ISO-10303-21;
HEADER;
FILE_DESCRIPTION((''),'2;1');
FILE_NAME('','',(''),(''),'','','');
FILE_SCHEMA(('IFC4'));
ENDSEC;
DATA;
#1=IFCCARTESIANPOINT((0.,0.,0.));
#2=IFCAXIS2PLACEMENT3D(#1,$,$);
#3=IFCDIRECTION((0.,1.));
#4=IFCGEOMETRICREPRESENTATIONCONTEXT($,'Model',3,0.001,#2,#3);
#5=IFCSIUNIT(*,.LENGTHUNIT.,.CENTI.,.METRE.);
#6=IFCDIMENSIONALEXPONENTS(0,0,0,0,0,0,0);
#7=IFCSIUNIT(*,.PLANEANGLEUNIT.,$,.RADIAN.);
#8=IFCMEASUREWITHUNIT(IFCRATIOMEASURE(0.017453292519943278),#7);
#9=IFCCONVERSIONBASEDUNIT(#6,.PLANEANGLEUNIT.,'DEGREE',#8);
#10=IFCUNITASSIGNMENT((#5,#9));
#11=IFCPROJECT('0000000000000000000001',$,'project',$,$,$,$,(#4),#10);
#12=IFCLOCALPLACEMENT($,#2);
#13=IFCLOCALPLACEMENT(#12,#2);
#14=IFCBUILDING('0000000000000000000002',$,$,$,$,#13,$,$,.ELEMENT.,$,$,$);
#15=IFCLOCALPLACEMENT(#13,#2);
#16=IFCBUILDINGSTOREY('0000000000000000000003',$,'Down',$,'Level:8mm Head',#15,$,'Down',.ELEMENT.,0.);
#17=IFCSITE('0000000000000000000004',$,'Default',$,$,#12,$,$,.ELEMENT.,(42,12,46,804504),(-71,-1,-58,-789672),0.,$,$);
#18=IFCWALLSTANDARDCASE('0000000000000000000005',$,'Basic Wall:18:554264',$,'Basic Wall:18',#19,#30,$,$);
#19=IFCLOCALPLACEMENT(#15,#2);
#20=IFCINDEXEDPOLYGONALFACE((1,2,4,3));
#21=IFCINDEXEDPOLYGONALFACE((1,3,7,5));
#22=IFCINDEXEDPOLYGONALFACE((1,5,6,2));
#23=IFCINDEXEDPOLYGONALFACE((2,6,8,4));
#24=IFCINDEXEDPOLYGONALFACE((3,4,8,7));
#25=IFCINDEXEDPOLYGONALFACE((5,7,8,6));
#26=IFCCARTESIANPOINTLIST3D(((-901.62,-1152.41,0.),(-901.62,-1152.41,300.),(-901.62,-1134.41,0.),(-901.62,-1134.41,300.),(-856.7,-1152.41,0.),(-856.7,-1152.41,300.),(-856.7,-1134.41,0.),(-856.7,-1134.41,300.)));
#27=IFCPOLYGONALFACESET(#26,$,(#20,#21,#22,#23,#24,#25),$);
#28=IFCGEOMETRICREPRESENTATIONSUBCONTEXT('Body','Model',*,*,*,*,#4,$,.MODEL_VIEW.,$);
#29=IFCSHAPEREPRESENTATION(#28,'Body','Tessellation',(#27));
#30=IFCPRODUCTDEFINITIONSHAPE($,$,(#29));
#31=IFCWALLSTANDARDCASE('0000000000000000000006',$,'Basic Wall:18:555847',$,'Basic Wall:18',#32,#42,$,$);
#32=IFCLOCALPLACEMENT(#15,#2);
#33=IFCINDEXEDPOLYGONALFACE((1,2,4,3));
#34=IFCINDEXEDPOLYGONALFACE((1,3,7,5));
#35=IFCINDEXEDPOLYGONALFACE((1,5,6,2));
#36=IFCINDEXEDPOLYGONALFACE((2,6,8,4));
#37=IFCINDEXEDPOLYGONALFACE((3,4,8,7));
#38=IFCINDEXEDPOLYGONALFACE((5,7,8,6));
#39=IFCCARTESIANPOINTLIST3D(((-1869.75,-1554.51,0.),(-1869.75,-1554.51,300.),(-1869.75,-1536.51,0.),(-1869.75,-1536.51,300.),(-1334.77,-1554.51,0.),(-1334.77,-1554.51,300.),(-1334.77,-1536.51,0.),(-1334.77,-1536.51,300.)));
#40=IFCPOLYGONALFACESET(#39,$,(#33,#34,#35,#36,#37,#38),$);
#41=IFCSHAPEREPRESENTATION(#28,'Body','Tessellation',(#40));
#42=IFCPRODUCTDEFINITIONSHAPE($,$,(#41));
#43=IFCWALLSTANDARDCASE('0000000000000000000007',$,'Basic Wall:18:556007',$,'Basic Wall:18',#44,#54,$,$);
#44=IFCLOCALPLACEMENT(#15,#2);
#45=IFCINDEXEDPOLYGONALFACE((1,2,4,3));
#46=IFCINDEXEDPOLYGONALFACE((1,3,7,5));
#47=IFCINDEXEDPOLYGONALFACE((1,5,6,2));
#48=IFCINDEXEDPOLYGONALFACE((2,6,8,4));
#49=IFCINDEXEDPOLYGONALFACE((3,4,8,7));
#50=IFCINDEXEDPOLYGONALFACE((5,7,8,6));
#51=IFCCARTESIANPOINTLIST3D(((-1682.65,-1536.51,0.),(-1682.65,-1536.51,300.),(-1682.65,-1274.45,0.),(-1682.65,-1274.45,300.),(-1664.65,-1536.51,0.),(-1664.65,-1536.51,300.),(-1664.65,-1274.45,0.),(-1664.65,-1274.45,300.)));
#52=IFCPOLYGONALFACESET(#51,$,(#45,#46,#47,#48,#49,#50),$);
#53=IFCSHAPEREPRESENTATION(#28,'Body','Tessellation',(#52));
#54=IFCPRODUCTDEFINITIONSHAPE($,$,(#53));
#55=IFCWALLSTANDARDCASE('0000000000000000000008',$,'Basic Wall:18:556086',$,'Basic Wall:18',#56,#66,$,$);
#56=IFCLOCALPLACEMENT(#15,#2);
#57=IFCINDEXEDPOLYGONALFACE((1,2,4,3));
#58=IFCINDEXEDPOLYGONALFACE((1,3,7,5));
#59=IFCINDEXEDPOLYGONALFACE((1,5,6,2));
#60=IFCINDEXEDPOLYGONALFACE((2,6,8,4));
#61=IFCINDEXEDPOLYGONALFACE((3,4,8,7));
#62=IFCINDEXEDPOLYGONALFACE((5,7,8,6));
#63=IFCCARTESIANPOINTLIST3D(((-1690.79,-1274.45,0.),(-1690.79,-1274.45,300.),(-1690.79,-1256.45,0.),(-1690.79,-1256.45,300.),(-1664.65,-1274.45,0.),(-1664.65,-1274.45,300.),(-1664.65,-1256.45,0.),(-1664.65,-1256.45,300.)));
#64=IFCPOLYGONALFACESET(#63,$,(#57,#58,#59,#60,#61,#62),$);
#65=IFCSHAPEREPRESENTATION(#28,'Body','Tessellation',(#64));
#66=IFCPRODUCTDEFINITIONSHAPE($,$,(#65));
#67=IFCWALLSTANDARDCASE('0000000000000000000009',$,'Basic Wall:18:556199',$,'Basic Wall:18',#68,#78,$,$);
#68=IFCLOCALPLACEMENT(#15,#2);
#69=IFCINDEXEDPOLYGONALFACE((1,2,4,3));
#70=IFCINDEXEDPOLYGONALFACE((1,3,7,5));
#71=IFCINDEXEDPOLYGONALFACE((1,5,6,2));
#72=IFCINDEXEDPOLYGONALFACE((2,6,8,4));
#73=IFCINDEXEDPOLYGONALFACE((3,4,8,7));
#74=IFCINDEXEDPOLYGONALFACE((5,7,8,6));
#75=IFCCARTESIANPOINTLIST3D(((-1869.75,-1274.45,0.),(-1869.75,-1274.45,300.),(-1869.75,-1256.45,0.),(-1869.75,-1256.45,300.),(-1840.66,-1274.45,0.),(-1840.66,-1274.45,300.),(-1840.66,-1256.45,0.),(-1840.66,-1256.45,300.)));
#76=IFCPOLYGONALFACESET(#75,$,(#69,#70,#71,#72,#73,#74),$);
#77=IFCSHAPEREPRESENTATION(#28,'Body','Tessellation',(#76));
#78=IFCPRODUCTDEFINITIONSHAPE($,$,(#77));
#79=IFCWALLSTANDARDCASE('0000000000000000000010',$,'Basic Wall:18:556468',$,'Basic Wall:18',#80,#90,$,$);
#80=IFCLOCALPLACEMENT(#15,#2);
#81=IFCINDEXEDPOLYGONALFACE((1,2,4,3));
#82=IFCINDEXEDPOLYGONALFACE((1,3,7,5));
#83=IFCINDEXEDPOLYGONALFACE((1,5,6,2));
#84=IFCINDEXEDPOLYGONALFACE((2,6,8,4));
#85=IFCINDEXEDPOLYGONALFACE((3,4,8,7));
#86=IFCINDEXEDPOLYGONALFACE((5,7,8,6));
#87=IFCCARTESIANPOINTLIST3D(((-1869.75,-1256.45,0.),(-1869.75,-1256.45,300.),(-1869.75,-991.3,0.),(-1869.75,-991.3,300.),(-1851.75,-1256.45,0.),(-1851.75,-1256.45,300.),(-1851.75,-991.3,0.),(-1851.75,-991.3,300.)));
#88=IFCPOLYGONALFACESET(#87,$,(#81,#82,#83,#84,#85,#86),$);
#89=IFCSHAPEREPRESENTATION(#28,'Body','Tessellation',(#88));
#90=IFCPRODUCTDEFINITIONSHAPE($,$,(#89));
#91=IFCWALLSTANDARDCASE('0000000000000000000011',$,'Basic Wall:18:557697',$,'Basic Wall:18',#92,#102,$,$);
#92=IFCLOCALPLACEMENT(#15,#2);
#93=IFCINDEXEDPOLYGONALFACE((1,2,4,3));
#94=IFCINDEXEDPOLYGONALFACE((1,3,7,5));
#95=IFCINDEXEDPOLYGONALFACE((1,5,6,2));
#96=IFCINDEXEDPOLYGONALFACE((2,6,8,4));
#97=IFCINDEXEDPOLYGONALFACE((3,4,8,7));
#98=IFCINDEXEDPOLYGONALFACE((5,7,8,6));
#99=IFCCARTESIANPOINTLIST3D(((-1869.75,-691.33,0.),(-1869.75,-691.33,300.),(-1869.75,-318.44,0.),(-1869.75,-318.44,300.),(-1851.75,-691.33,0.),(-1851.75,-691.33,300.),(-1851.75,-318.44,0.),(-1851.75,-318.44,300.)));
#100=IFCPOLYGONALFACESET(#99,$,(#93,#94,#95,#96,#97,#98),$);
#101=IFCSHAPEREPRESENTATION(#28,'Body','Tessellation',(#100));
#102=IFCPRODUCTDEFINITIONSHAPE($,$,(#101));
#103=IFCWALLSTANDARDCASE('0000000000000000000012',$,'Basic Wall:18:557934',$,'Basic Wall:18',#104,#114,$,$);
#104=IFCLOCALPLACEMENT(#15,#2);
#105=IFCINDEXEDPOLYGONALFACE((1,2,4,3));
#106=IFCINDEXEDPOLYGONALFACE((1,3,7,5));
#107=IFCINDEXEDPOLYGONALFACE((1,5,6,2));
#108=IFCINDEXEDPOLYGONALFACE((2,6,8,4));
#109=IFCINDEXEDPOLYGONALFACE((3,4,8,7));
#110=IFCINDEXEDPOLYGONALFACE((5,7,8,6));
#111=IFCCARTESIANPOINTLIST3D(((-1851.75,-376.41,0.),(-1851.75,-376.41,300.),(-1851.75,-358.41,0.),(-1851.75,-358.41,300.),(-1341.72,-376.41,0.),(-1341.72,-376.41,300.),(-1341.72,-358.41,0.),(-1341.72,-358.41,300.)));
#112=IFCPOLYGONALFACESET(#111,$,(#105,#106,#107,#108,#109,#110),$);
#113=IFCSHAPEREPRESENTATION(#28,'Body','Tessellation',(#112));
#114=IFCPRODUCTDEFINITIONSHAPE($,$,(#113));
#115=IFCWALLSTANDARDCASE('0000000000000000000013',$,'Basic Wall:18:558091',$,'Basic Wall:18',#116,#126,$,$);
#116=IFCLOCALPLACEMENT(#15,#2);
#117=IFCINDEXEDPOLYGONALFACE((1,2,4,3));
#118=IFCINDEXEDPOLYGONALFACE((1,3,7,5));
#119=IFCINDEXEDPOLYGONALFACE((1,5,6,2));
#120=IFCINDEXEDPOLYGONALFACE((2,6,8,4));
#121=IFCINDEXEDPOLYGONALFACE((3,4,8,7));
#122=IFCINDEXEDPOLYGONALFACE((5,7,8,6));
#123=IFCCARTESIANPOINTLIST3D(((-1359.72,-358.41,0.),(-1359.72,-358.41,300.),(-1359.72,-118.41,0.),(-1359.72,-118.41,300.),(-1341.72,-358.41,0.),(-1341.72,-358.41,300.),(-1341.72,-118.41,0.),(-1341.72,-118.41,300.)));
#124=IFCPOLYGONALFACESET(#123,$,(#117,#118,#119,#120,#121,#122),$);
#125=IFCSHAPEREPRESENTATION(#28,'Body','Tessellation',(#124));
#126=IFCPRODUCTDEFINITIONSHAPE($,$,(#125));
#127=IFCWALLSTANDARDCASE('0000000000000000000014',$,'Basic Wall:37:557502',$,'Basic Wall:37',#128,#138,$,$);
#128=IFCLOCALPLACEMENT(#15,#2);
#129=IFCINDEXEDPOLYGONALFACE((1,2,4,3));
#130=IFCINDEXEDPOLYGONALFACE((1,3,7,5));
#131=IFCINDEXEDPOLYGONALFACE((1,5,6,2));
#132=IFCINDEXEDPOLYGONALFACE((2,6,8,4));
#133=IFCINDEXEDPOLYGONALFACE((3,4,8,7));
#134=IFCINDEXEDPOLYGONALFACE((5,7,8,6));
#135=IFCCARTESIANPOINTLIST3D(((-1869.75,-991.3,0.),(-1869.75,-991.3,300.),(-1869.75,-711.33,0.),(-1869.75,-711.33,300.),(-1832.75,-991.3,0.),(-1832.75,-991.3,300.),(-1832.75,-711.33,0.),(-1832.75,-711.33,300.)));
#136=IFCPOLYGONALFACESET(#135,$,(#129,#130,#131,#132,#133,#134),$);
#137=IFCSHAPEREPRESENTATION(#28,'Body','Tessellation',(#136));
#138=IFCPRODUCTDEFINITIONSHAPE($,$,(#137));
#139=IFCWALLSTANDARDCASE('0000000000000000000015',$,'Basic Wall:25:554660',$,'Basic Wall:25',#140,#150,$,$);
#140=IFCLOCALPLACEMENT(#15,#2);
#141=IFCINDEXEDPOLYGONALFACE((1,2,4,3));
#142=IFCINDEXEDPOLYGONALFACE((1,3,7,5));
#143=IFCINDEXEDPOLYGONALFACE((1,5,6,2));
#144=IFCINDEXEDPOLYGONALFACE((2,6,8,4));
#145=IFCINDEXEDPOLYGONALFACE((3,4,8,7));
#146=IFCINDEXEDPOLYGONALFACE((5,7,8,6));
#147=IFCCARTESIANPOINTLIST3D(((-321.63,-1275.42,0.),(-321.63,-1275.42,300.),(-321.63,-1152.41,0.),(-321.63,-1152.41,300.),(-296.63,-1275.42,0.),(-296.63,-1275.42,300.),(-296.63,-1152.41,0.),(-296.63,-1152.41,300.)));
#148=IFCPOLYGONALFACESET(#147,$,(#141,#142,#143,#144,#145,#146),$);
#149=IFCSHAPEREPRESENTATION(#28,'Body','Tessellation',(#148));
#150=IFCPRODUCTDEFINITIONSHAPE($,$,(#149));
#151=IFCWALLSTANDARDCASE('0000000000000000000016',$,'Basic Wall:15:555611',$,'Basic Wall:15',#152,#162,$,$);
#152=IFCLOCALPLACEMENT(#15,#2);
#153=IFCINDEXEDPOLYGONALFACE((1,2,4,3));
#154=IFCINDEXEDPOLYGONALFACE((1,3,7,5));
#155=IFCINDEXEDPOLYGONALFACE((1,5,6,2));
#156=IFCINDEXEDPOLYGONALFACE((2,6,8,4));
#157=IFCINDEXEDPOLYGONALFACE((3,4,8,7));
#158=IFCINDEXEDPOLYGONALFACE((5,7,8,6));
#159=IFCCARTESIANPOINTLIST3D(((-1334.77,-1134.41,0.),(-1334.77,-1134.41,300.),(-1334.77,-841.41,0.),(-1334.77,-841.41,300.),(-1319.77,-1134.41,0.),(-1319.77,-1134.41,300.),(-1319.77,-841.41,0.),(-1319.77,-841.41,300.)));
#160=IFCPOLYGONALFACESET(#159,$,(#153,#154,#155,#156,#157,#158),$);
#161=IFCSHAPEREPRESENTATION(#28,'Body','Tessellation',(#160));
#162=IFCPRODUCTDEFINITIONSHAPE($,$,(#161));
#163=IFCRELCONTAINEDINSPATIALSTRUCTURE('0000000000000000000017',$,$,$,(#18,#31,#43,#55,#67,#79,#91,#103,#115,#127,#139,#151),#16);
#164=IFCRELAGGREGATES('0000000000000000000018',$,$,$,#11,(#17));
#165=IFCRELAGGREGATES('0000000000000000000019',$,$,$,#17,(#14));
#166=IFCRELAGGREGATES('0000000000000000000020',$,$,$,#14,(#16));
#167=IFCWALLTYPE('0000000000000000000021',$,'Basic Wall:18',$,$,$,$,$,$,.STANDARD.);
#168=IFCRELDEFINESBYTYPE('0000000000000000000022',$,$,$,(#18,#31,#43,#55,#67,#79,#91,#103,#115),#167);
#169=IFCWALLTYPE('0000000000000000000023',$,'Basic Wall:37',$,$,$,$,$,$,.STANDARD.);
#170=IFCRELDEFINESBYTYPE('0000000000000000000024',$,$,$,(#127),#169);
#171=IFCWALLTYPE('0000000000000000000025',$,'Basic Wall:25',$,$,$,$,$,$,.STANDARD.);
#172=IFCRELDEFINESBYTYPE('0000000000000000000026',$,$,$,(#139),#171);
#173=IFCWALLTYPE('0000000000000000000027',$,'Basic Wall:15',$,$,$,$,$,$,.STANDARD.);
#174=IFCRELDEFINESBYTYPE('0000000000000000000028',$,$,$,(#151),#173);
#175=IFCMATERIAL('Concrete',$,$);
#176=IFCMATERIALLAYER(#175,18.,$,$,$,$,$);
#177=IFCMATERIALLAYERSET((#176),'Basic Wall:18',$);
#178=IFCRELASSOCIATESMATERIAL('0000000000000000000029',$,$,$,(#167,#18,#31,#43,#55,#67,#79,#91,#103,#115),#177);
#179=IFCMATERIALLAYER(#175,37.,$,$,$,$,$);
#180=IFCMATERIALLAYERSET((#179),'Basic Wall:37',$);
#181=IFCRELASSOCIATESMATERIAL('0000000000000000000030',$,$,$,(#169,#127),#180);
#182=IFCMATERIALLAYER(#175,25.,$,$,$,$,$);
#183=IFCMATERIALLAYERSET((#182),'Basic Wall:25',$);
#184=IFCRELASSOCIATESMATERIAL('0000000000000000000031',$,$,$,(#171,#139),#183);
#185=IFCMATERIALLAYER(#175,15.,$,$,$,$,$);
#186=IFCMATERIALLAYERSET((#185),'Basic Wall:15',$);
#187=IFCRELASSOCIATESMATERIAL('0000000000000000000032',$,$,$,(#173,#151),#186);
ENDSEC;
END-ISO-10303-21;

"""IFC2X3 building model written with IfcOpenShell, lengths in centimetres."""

from ifc_helpers import new_model, entity, si_unit, converted_unit, direction, frame, frame_2d, origin, place, context, subcontext, project, spatial, rectangle, extrude, material, layer, layer_set, layer_usage, type_object, element, save


model = new_model("IFC2X3")

# Units and contexts
model_context = context("Model", 3, precision=0.001, world=origin(), true_north=direction((0.0, 1.0)))
body_context = subcontext(model_context, "Body", "Model", "MODEL_VIEW")
ifc_project = project(units=[si_unit("LENGTHUNIT", "METRE", prefix="CENTI"), converted_unit("PLANEANGLEUNIT", "DEGREE", entity("IfcRatioMeasure", 0.017453292519943278), si_unit("PLANEANGLEUNIT", "RADIAN"), dimensions=[0, 0, 0, 0, 0, 0, 0])], contexts=[model_context])

# Site, building, storey
site_placement = place(None, origin())
site = spatial("IfcSite", under=ifc_project, at=site_placement, Name="Default", CompositionType="ELEMENT", RefLatitude=(42, 12, 46, 804504), RefLongitude=(-71, -1, -58, -789672), RefElevation=0.0)
building_placement = place(site_placement, origin())
building = spatial("IfcBuilding", under=site, at=building_placement, CompositionType="ELEMENT")
storey_placement = place(building_placement, origin())
storey = spatial("IfcBuildingStorey", under=building, at=storey_placement, Name="Down", ObjectType="Level:8mm Head", LongName="Down", CompositionType="ELEMENT", Elevation=0.0)

# Walls
ifc_material = material(Name="Concrete")
ifc_layer_1 = layer(ifc_material, 18.0)
ifc_layer_set_1 = layer_set([ifc_layer_1], Name="Basic Wall:18")
wall_type_1 = type_object("IfcWallType", Name="Basic Wall:18", PredefinedType="STANDARD", material=ifc_layer_set_1)
ifc_layer_usage_1 = layer_usage(ifc_layer_set_1, "AXIS2", "POSITIVE", -9.0)
wall_1_placement = place(storey_placement, frame((-856.7, -1143.41, 0.0), z_axis=(0.0, 0.0, 1.0), x_axis=(-1.0, 0.0, 0.0)))
element("IfcWallStandardCase", 1, at=wall_1_placement, inside=storey, type_object=wall_type_1, material=ifc_layer_usage_1, Name="Basic Wall:18:554264", ObjectType="Basic Wall:18", context=body_context, shape_type="SweptSolid", body=[
    extrude(rectangle(XDim=44.92, YDim=18.0, at=frame_2d((22.46, 0.0), x_axis=(-1.0, 0.0))), origin(), (0.0, 0.0, 1.0), 300.0),
])
ifc_layer_usage_2 = layer_usage(ifc_layer_set_1, "AXIS2", "NEGATIVE", 9.0)
wall_2_placement = place(storey_placement, frame((-1334.77, -1545.51, 0.0), z_axis=(0.0, 0.0, 1.0), x_axis=(-1.0, 0.0, 0.0)))
element("IfcWallStandardCase", 2, at=wall_2_placement, inside=storey, type_object=wall_type_1, material=ifc_layer_usage_2, Name="Basic Wall:18:555847", ObjectType="Basic Wall:18", context=body_context, shape_type="SweptSolid", body=[
    extrude(rectangle(XDim=534.98, YDim=18.0, at=frame_2d((267.49, 0.0), x_axis=(-1.0, 0.0))), origin(), (0.0, 0.0, 1.0), 300.0),
])
ifc_layer_usage_3 = layer_usage(ifc_layer_set_1, "AXIS2", "POSITIVE", -9.0)
wall_3_placement = place(storey_placement, frame((-1673.65, -1536.51, 0.0), z_axis=(0.0, 0.0, 1.0), x_axis=(0.0, 1.0, 0.0)))
element("IfcWallStandardCase", 3, at=wall_3_placement, inside=storey, type_object=wall_type_1, material=ifc_layer_usage_3, Name="Basic Wall:18:556007", ObjectType="Basic Wall:18", context=body_context, shape_type="SweptSolid", body=[
    extrude(rectangle(XDim=262.05, YDim=18.0, at=frame_2d((131.03, 0.0), x_axis=(-1.0, 0.0))), origin(), (0.0, 0.0, 1.0), 300.0),
])
ifc_layer_usage_4 = layer_usage(ifc_layer_set_1, "AXIS2", "POSITIVE", -9.0)
wall_4_placement = place(storey_placement, frame((-1664.65, -1265.45, 0.0), z_axis=(0.0, 0.0, 1.0), x_axis=(-1.0, 0.0, 0.0)))
element("IfcWallStandardCase", 4, at=wall_4_placement, inside=storey, type_object=wall_type_1, material=ifc_layer_usage_4, Name="Basic Wall:18:556086", ObjectType="Basic Wall:18", context=body_context, shape_type="SweptSolid", body=[
    extrude(rectangle(XDim=26.14, YDim=18.0, at=frame_2d((13.07, 0.0), x_axis=(-1.0, 0.0))), origin(), (0.0, 0.0, 1.0), 300.0),
])
ifc_layer_usage_5 = layer_usage(ifc_layer_set_1, "AXIS2", "POSITIVE", -9.0)
wall_5_placement = place(storey_placement, frame((-1840.66, -1265.45, 0.0), z_axis=(0.0, 0.0, 1.0), x_axis=(-1.0, 0.0, 0.0)))
element("IfcWallStandardCase", 5, at=wall_5_placement, inside=storey, type_object=wall_type_1, material=ifc_layer_usage_5, Name="Basic Wall:18:556199", ObjectType="Basic Wall:18", context=body_context, shape_type="SweptSolid", body=[
    extrude(rectangle(XDim=29.09, YDim=18.0, at=frame_2d((14.54, 0.0), x_axis=(-1.0, 0.0))), origin(), (0.0, 0.0, 1.0), 300.0),
])
ifc_layer_usage_6 = layer_usage(ifc_layer_set_1, "AXIS2", "NEGATIVE", 9.0)
wall_6_placement = place(storey_placement, frame((-1860.75, -1256.45, 0.0), z_axis=(0.0, 0.0, 1.0), x_axis=(0.0, 1.0, 0.0)))
element("IfcWallStandardCase", 6, at=wall_6_placement, inside=storey, type_object=wall_type_1, material=ifc_layer_usage_6, Name="Basic Wall:18:556468", ObjectType="Basic Wall:18", context=body_context, shape_type="SweptSolid", body=[
    extrude(rectangle(XDim=265.15, YDim=18.0, at=frame_2d((132.57, 0.0), x_axis=(-1.0, 0.0))), origin(), (0.0, 0.0, 1.0), 300.0),
])
ifc_layer_usage_7 = layer_usage(ifc_layer_set_1, "AXIS2", "NEGATIVE", 9.0)
wall_7_placement = place(storey_placement, frame((-1860.75, -691.33, 0.0), z_axis=(0.0, 0.0, 1.0), x_axis=(0.0, 1.0, 0.0)))
element("IfcWallStandardCase", 7, at=wall_7_placement, inside=storey, type_object=wall_type_1, material=ifc_layer_usage_7, Name="Basic Wall:18:557697", ObjectType="Basic Wall:18", context=body_context, shape_type="SweptSolid", body=[
    extrude(rectangle(XDim=372.88, YDim=18.0, at=frame_2d((186.44, 0.0), x_axis=(-1.0, 0.0))), origin(), (0.0, 0.0, 1.0), 300.0),
])
ifc_layer_usage_8 = layer_usage(ifc_layer_set_1, "AXIS2", "POSITIVE", -9.0)
wall_8_placement = place(storey_placement, frame((-1851.75, -367.41, 0.0)))
element("IfcWallStandardCase", 8, at=wall_8_placement, inside=storey, type_object=wall_type_1, material=ifc_layer_usage_8, Name="Basic Wall:18:557934", ObjectType="Basic Wall:18", context=body_context, shape_type="SweptSolid", body=[
    extrude(rectangle(XDim=510.02, YDim=18.0, at=frame_2d((255.01, 0.0), x_axis=(-1.0, 0.0))), origin(), (0.0, 0.0, 1.0), 300.0),
])
ifc_layer_usage_9 = layer_usage(ifc_layer_set_1, "AXIS2", "POSITIVE", -9.0)
wall_9_placement = place(storey_placement, frame((-1350.72, -358.41, 0.0), z_axis=(0.0, 0.0, 1.0), x_axis=(0.0, 1.0, 0.0)))
element("IfcWallStandardCase", 9, at=wall_9_placement, inside=storey, type_object=wall_type_1, material=ifc_layer_usage_9, Name="Basic Wall:18:558091", ObjectType="Basic Wall:18", context=body_context, shape_type="SweptSolid", body=[
    extrude(rectangle(XDim=240.0, YDim=18.0, at=frame_2d((120.0, 0.0), x_axis=(-1.0, 0.0))), origin(), (0.0, 0.0, 1.0), 300.0),
])
ifc_layer_2 = layer(ifc_material, 37.0)
ifc_layer_set_2 = layer_set([ifc_layer_2], Name="Basic Wall:37")
ifc_layer_usage_10 = layer_usage(ifc_layer_set_2, "AXIS2", "NEGATIVE", 18.5)
wall_type_2 = type_object("IfcWallType", Name="Basic Wall:37", PredefinedType="STANDARD", material=ifc_layer_set_2)
wall_10_placement = place(storey_placement, frame((-1851.25, -991.3, 0.0), z_axis=(0.0, 0.0, 1.0), x_axis=(0.0, 1.0, 0.0)))
element("IfcWallStandardCase", 10, at=wall_10_placement, inside=storey, type_object=wall_type_2, material=ifc_layer_usage_10, Name="Basic Wall:37:557502", ObjectType="Basic Wall:37", context=body_context, shape_type="SweptSolid", body=[
    extrude(rectangle(XDim=279.98, YDim=37.0, at=frame_2d((139.99, 0.0), x_axis=(-1.0, 0.0))), origin(), (0.0, 0.0, 1.0), 300.0),
])
ifc_layer_3 = layer(ifc_material, 25.0)
ifc_layer_set_3 = layer_set([ifc_layer_3], Name="Basic Wall:25")
ifc_layer_usage_11 = layer_usage(ifc_layer_set_3, "AXIS2", "NEGATIVE", 12.5)
wall_type_3 = type_object("IfcWallType", Name="Basic Wall:25", PredefinedType="STANDARD", material=ifc_layer_set_3)
wall_11_placement = place(storey_placement, frame((-309.13, -1152.41, 0.0), z_axis=(0.0, 0.0, 1.0), x_axis=(0.0, -1.0, 0.0)))
element("IfcWallStandardCase", 11, at=wall_11_placement, inside=storey, type_object=wall_type_3, material=ifc_layer_usage_11, Name="Basic Wall:25:554660", ObjectType="Basic Wall:25", context=body_context, shape_type="SweptSolid", body=[
    extrude(rectangle(XDim=123.02, YDim=25.0, at=frame_2d((61.51, 0.0), x_axis=(-1.0, 0.0))), origin(), (0.0, 0.0, 1.0), 300.0),
])
ifc_layer_4 = layer(ifc_material, 15.0)
ifc_layer_set_4 = layer_set([ifc_layer_4], Name="Basic Wall:15")
ifc_layer_usage_12 = layer_usage(ifc_layer_set_4, "AXIS2", "NEGATIVE", 7.5)
wall_type_4 = type_object("IfcWallType", Name="Basic Wall:15", PredefinedType="STANDARD", material=ifc_layer_set_4)
wall_12_placement = place(storey_placement, frame((-1327.27, -1134.41, 0.0), z_axis=(0.0, 0.0, 1.0), x_axis=(0.0, 1.0, 0.0)))
element("IfcWallStandardCase", 12, at=wall_12_placement, inside=storey, type_object=wall_type_4, material=ifc_layer_usage_12, Name="Basic Wall:15:555611", ObjectType="Basic Wall:15", context=body_context, shape_type="SweptSolid", body=[
    extrude(rectangle(XDim=293.0, YDim=15.0, at=frame_2d((146.5, 0.0), x_axis=(-1.0, 0.0))), origin(), (0.0, 0.0, 1.0), 300.0),
])

save(model, "model.ifc")
